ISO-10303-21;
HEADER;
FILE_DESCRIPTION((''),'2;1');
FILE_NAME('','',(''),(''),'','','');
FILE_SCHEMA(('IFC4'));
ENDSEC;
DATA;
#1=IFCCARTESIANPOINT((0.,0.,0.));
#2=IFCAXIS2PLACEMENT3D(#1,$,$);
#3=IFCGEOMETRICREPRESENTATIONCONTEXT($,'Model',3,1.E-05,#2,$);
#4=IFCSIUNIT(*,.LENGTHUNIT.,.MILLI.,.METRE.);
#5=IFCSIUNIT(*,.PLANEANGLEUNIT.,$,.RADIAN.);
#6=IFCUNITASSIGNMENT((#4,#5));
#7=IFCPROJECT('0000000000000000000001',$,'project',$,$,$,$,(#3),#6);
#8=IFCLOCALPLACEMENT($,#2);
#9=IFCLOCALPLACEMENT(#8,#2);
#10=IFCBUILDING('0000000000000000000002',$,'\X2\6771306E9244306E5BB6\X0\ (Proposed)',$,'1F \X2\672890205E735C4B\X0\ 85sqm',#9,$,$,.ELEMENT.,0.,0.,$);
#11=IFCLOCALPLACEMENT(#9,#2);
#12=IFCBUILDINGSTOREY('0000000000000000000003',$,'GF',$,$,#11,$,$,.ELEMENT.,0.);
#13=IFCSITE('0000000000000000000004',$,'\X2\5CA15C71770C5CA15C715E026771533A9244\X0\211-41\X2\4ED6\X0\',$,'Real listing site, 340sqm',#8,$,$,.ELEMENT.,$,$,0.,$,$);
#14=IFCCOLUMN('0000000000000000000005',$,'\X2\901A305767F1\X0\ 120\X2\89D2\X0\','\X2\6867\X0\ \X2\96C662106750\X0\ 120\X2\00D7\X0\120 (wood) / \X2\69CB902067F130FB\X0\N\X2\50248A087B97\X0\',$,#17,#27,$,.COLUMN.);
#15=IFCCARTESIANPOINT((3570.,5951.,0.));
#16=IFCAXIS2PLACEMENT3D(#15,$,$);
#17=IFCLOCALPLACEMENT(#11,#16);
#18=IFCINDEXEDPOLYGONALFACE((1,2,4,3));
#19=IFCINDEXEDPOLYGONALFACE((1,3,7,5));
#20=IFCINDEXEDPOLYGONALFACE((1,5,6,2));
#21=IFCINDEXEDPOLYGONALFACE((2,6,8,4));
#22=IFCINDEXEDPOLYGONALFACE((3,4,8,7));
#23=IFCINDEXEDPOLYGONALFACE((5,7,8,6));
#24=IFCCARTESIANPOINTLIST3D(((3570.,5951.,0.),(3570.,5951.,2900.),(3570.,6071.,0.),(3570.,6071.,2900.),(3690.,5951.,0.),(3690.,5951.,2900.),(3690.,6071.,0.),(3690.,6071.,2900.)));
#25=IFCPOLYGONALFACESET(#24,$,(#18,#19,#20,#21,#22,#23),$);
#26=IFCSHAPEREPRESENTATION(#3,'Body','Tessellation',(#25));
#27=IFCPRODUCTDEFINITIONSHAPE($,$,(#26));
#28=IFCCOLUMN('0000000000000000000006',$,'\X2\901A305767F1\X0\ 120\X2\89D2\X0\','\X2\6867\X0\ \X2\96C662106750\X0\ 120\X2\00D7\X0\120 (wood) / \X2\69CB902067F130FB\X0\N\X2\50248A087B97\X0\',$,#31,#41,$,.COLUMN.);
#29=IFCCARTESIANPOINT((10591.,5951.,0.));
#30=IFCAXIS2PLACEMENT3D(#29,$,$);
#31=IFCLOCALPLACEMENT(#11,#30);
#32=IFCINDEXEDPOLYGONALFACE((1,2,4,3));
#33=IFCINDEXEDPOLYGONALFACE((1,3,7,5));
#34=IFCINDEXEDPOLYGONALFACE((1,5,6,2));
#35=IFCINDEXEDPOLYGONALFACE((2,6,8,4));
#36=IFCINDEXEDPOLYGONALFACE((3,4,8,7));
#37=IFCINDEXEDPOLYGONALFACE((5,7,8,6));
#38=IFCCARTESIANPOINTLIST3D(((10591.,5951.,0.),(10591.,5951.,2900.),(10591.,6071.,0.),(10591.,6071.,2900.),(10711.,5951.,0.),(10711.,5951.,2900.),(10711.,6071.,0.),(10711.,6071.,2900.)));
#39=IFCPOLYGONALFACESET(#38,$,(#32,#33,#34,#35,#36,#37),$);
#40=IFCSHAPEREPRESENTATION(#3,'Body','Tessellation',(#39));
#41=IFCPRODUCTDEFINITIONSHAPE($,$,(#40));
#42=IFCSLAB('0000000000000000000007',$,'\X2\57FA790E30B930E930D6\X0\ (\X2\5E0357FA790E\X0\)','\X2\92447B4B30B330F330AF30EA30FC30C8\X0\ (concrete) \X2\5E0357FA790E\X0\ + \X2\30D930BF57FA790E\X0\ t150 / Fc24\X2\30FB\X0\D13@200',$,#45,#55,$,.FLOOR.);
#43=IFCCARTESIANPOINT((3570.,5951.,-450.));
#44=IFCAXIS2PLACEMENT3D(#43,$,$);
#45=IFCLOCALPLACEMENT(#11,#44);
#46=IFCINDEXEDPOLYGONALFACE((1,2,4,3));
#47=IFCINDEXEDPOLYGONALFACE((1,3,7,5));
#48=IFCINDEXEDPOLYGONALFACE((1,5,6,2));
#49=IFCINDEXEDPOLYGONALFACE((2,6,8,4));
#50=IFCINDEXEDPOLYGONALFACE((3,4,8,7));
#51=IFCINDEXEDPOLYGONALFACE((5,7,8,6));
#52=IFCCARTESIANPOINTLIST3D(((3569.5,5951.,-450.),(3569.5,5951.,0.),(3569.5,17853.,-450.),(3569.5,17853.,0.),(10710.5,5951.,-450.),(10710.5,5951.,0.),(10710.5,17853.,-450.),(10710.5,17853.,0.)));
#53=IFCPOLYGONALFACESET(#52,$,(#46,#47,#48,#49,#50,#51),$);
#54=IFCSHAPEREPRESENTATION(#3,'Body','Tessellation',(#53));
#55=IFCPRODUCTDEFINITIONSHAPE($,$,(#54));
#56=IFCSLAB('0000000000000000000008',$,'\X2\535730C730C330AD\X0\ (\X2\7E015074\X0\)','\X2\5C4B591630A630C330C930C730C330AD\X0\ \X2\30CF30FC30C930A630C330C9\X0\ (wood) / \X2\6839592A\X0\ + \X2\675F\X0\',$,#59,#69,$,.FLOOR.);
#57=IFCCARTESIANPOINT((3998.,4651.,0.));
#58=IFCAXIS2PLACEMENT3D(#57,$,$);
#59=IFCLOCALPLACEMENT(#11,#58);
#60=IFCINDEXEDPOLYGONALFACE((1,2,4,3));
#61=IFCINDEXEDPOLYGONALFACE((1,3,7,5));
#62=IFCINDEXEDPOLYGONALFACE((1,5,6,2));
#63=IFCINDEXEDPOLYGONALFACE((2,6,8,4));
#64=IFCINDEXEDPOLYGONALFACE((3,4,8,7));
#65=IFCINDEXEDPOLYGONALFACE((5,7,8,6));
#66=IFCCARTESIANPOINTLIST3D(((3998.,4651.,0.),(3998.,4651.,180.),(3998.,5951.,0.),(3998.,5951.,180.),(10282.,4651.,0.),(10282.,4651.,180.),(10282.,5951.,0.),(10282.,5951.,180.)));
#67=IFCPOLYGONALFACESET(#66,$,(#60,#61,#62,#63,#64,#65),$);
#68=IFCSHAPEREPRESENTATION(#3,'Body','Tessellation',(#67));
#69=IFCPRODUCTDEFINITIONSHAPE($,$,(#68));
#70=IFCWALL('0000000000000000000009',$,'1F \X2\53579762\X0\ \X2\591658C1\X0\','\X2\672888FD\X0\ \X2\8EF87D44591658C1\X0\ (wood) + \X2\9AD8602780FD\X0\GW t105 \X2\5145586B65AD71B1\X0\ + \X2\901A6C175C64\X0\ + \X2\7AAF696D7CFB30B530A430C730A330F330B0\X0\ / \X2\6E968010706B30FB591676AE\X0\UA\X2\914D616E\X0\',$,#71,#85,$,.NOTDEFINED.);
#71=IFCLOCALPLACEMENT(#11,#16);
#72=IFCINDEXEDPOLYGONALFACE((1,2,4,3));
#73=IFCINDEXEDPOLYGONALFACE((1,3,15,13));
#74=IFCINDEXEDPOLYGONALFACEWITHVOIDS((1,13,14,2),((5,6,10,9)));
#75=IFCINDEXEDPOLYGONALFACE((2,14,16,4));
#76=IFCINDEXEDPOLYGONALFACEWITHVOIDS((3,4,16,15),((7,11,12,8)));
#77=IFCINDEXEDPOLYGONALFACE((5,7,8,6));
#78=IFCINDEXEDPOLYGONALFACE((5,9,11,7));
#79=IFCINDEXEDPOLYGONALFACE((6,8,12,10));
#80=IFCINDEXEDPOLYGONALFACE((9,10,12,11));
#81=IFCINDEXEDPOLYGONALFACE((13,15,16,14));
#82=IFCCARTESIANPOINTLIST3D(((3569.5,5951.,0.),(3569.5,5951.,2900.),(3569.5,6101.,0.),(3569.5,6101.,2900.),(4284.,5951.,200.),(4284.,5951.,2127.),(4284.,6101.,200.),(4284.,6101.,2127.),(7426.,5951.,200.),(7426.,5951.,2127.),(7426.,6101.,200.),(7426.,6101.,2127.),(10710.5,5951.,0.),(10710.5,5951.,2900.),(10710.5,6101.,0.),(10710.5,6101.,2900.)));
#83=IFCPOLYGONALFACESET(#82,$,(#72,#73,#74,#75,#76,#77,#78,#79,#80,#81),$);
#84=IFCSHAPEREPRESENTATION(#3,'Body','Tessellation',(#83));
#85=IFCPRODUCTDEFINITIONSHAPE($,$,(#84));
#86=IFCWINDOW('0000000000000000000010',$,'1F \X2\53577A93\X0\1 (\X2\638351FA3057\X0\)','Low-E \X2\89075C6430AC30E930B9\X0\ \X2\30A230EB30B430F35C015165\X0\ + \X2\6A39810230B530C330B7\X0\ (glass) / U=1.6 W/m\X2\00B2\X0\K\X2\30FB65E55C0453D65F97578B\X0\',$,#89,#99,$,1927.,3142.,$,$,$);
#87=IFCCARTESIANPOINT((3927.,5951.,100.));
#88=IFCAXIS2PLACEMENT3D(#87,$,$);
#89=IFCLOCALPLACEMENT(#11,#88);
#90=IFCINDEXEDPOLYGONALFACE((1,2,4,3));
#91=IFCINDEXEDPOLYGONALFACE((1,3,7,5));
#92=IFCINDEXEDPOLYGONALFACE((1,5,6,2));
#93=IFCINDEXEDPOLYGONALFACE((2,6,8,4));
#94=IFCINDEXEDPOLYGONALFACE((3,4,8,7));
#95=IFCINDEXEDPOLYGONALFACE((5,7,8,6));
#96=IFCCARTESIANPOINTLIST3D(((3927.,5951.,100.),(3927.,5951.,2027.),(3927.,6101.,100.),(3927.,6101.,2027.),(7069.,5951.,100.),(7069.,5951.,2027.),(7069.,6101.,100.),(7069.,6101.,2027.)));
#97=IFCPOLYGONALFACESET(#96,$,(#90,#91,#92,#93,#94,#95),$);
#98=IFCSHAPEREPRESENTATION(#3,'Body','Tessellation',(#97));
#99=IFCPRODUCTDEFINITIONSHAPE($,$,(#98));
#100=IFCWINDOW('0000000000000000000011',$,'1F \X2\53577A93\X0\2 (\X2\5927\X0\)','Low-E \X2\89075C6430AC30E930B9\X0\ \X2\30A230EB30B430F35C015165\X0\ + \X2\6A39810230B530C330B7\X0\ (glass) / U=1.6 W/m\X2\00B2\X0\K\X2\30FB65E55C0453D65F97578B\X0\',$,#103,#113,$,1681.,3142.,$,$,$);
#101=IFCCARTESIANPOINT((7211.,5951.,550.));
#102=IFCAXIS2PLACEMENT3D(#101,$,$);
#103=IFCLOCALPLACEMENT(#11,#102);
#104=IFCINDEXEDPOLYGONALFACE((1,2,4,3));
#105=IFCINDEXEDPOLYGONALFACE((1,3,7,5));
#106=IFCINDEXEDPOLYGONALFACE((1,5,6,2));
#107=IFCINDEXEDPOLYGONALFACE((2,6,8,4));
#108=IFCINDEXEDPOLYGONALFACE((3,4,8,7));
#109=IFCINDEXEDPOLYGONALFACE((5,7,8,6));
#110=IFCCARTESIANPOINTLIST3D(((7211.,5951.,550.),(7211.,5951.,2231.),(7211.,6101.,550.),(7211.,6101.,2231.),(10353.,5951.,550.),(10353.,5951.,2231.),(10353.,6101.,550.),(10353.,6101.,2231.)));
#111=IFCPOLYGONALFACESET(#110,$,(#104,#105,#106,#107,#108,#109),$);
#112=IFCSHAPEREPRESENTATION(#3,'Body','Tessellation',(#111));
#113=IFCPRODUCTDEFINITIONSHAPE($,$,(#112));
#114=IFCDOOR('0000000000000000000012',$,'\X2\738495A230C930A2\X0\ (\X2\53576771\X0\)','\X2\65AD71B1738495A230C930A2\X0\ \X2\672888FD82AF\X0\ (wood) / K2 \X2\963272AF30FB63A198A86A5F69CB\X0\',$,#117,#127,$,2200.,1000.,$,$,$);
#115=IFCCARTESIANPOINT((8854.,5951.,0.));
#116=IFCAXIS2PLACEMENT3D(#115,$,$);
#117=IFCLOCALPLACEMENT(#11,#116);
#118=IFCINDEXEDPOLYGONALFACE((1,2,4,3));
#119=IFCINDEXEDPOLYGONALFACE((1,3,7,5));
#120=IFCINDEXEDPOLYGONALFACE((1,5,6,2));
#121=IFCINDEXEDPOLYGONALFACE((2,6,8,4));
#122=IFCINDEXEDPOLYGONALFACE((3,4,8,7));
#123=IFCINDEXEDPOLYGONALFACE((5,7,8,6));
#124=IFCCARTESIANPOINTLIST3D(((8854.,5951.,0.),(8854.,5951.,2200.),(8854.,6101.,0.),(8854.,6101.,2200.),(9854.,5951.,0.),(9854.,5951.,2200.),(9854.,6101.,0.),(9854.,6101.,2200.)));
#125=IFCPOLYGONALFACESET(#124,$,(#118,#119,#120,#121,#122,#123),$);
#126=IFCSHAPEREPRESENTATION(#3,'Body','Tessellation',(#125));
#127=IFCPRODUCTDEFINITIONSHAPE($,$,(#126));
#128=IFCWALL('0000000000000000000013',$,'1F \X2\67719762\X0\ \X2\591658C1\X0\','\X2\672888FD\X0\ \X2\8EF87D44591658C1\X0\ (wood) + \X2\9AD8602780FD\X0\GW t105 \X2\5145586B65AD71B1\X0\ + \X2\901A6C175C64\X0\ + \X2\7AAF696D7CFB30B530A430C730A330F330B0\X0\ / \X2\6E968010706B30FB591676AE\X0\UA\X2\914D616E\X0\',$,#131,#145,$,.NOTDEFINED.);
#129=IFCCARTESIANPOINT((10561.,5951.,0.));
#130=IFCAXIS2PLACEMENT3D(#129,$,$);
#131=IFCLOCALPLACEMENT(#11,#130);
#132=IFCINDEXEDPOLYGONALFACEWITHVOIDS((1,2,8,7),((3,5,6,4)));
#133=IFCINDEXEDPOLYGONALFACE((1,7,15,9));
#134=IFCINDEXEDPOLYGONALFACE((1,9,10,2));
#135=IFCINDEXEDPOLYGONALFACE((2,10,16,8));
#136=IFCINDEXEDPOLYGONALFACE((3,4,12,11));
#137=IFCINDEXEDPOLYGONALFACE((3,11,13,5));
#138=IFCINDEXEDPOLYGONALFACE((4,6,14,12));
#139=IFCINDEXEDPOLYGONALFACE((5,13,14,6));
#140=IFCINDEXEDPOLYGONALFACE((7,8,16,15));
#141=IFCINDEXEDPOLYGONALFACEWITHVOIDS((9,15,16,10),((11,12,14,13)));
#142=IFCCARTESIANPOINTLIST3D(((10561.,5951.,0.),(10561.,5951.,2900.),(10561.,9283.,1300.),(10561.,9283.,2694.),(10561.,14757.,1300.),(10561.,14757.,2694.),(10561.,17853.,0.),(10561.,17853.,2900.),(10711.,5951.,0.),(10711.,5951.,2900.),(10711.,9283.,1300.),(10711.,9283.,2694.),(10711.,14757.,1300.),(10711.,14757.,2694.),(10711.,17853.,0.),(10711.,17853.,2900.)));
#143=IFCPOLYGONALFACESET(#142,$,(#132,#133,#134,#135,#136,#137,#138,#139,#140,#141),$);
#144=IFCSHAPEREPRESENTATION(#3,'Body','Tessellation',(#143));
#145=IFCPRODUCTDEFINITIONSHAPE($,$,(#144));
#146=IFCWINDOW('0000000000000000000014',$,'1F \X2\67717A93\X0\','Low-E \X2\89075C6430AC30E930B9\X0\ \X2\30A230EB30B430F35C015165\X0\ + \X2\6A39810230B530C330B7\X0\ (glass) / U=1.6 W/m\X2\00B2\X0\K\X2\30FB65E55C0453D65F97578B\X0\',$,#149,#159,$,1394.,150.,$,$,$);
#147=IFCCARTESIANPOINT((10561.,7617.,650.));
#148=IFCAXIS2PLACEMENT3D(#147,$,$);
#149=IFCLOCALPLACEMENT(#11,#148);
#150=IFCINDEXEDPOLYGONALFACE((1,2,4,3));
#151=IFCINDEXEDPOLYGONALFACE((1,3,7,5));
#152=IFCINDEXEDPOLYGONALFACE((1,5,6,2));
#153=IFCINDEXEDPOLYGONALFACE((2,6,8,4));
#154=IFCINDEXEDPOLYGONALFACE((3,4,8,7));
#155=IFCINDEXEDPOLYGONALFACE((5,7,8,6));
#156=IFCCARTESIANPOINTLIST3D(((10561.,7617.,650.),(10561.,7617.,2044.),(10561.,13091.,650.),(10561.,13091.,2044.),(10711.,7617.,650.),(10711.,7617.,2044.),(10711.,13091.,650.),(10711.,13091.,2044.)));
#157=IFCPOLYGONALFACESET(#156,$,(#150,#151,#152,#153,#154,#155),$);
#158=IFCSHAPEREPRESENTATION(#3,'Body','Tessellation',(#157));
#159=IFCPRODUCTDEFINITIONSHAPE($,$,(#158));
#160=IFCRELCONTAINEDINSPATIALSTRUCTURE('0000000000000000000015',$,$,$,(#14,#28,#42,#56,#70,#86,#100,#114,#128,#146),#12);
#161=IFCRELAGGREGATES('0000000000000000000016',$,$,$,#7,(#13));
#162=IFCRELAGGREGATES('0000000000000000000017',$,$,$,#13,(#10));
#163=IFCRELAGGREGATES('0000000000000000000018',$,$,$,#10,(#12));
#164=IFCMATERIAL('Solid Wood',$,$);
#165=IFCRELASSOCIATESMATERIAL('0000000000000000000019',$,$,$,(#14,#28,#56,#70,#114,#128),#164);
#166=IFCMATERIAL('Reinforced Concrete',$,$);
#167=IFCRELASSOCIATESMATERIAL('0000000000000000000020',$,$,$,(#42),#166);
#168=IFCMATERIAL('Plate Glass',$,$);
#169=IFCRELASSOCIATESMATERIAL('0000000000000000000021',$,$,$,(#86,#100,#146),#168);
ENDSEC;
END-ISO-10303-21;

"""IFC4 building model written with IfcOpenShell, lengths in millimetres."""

from ifc_helpers import new_model, si_unit, frame, frame_2d, origin, place, context, project, spatial, rectangle, extrude, material, element, fill, save


model = new_model("IFC4")

# Units and contexts
model_context = context("Model", 3, precision=1e-05, world=origin())
ifc_project = project(units=[si_unit("LENGTHUNIT", "METRE", prefix="MILLI"), si_unit("PLANEANGLEUNIT", "RADIAN")], contexts=[model_context])

# Site, building, storey
site_placement = place(None, origin())
site = spatial("IfcSite", under=ifc_project, at=site_placement, Name="岡山県岡山市東区鉄211-41他", ObjectType="Real listing site, 340sqm", CompositionType="ELEMENT", RefElevation=0.0)
building_placement = place(site_placement, origin())
building = spatial("IfcBuilding", under=site, at=building_placement, Name="東の鉄の家 (Proposed)", ObjectType="1F 木造平屋 85sqm", CompositionType="ELEMENT", ElevationOfRefHeight=0.0, ElevationOfTerrain=0.0)
storey_placement = place(building_placement, origin())
storey = spatial("IfcBuildingStorey", under=building, at=storey_placement, Name="GF", CompositionType="ELEMENT", Elevation=0.0)

# Columns
ifc_material_1 = material(Name="Solid Wood")
column_1_placement = place(storey_placement, frame((3570.0, 5951.0, 0.0)))
element("IfcColumn", 1, at=column_1_placement, inside=storey, material=ifc_material_1, Name="通し柱 120角", Description="桧 集成材 120×120 (wood) / 構造柱・N値計算", PredefinedType="COLUMN", context=model_context, shape_type="SweptSolid", body=[
    extrude(rectangle(XDim=120.0, YDim=120.0, at=frame_2d((60.0, 60.0))), frame((3570.0, 5951.0, 0.0)), (0.0, 0.0, 1.0), 2900.0),
])
column_2_placement = place(storey_placement, frame((10591.0, 5951.0, 0.0)))
element("IfcColumn", 2, at=column_2_placement, inside=storey, material=ifc_material_1, Name="通し柱 120角", Description="桧 集成材 120×120 (wood) / 構造柱・N値計算", PredefinedType="COLUMN", context=model_context, shape_type="SweptSolid", body=[
    extrude(rectangle(XDim=120.0, YDim=120.0, at=frame_2d((60.0, 60.0))), frame((10591.0, 5951.0, 0.0)), (0.0, 0.0, 1.0), 2900.0),
])

# Slabs
ifc_material_2 = material(Name="Reinforced Concrete")
slab_1_placement = place(storey_placement, frame((3570.0, 5951.0, -450.0)))
element("IfcSlab", 3, at=slab_1_placement, inside=storey, material=ifc_material_2, Name="基礎スラブ (布基礎)", Description="鉄筋コンクリート (concrete) 布基礎 + ベタ基礎 t150 / Fc24・D13@200", PredefinedType="FLOOR", context=model_context, shape_type="SweptSolid", body=[
    extrude(rectangle(XDim=7141.0, YDim=11902.0, at=frame_2d((3570.0, 5951.0))), frame((3570.0, 5951.0, -450.0)), (0.0, 0.0, 1.0), 450.0),
])
slab_2_placement = place(storey_placement, frame((3998.0, 4651.0, 0.0)))
element("IfcSlab", 4, at=slab_2_placement, inside=storey, material=ifc_material_1, Name="南デッキ (縁側)", Description="屋外ウッドデッキ ハードウッド (wood) / 根太 + 束", PredefinedType="FLOOR", context=model_context, shape_type="SweptSolid", body=[
    extrude(rectangle(XDim=6284.0, YDim=1300.0, at=frame_2d((3142.0, 650.0))), frame((3998.0, 4651.0, 0.0)), (0.0, 0.0, 1.0), 180.0),
])

# Wall, openings, windows, door
wall_1_placement = place(storey_placement, frame((3570.0, 5951.0, 0.0)))
wall_1 = element("IfcWall", 5, at=wall_1_placement, inside=storey, material=ifc_material_1, Name="1F 南面 外壁", Description="木製 軸組外壁 (wood) + 高性能GW t105 充填断熱 + 通気層 + 窯業系サイディング / 準耐火・外皮UA配慮", PredefinedType="NOTDEFINED", context=model_context, shape_type="SweptSolid", body=[
    extrude(rectangle(XDim=7141.0, YDim=150.0, at=frame_2d((3570.0, 75.0))), frame((3570.0, 5951.0, 0.0)), (0.0, 0.0, 1.0), 2900.0),
])
opening_1_placement = place(storey_placement, frame((3927.0, 5951.0, 100.0)))
opening_1 = element("IfcOpeningElement", 6, at=opening_1_placement, cuts=wall_1, PredefinedType="NOTDEFINED", context=model_context, shape_type="SweptSolid", body=[
    extrude(rectangle(XDim=3142.0, YDim=150.0, at=frame_2d((1571.0, 75.0))), frame((3927.0, 5951.0, 100.0)), (0.0, 0.0, 1.0), 1927.0),
])
opening_2_placement = place(storey_placement, frame((7211.0, 5951.0, 550.0)))
opening_2 = element("IfcOpeningElement", 7, at=opening_2_placement, cuts=wall_1, PredefinedType="NOTDEFINED", context=model_context, shape_type="SweptSolid", body=[
    extrude(rectangle(XDim=3142.0, YDim=150.0, at=frame_2d((1571.0, 75.0))), frame((7211.0, 5951.0, 550.0)), (0.0, 0.0, 1.0), 1681.0),
])
opening_3_placement = place(storey_placement, frame((8854.0, 5951.0, 0.0)))
opening_3 = element("IfcOpeningElement", 8, at=opening_3_placement, cuts=wall_1, PredefinedType="NOTDEFINED", context=model_context, shape_type="SweptSolid", body=[
    extrude(rectangle(XDim=1000.0, YDim=150.0, at=frame_2d((500.0, 75.0))), frame((8854.0, 5951.0, 0.0)), (0.0, 0.0, 1.0), 2200.0),
])
ifc_material_3 = material(Name="Plate Glass")
window_1_placement = place(storey_placement, frame((3927.0, 5951.0, 100.0)))
window_1 = element("IfcWindow", 9, at=window_1_placement, inside=storey, material=ifc_material_3, Name="1F 南窓1 (掃出し)", Description="Low-E 複層ガラス アルゴン封入 + 樹脂サッシ (glass) / U=1.6 W/m²K・日射取得型", OverallHeight=1927.0, OverallWidth=3142.0, context=model_context, shape_type="SweptSolid", body=[
    extrude(rectangle(XDim=3142.0, YDim=150.0, at=frame_2d((1571.0, 75.0))), frame((3927.0, 5951.0, 100.0)), (0.0, 0.0, 1.0), 1927.0),
])
fill(opening_1, window_1)
window_2_placement = place(storey_placement, frame((7211.0, 5951.0, 550.0)))
window_2 = element("IfcWindow", 10, at=window_2_placement, inside=storey, material=ifc_material_3, Name="1F 南窓2 (大)", Description="Low-E 複層ガラス アルゴン封入 + 樹脂サッシ (glass) / U=1.6 W/m²K・日射取得型", OverallHeight=1681.0, OverallWidth=3142.0, context=model_context, shape_type="SweptSolid", body=[
    extrude(rectangle(XDim=3142.0, YDim=150.0, at=frame_2d((1571.0, 75.0))), frame((7211.0, 5951.0, 550.0)), (0.0, 0.0, 1.0), 1681.0),
])
fill(opening_2, window_2)
door_placement = place(storey_placement, frame((8854.0, 5951.0, 0.0)))
door = element("IfcDoor", 11, at=door_placement, inside=storey, material=ifc_material_1, Name="玄関ドア (南東)", Description="断熱玄関ドア 木製芯 (wood) / K2 防犯・採風機構", OverallHeight=2200.0, OverallWidth=1000.0, context=model_context, shape_type="SweptSolid", body=[
    extrude(rectangle(XDim=1000.0, YDim=150.0, at=frame_2d((500.0, 75.0))), frame((8854.0, 5951.0, 0.0)), (0.0, 0.0, 1.0), 2200.0),
])
fill(opening_3, door)

# Wall, opening, window
wall_2_placement = place(storey_placement, frame((10561.0, 5951.0, 0.0)))
wall_2 = element("IfcWall", 12, at=wall_2_placement, inside=storey, material=ifc_material_1, Name="1F 東面 外壁", Description="木製 軸組外壁 (wood) + 高性能GW t105 充填断熱 + 通気層 + 窯業系サイディング / 準耐火・外皮UA配慮", PredefinedType="NOTDEFINED", context=model_context, shape_type="SweptSolid", body=[
    extrude(rectangle(XDim=150.0, YDim=11902.0, at=frame_2d((75.0, 5951.0))), frame((10561.0, 5951.0, 0.0)), (0.0, 0.0, 1.0), 2900.0),
])
opening_4_placement = place(storey_placement, frame((10561.0, 7617.0, 650.0)))
opening_4 = element("IfcOpeningElement", 13, at=opening_4_placement, cuts=wall_2, PredefinedType="NOTDEFINED", context=model_context, shape_type="SweptSolid", body=[
    extrude(rectangle(XDim=150.0, YDim=5474.0, at=frame_2d((75.0, 2737.0))), frame((10561.0, 7617.0, 650.0)), (0.0, 0.0, 1.0), 1394.0),
])
window_3_placement = place(storey_placement, frame((10561.0, 7617.0, 650.0)))
window_3 = element("IfcWindow", 14, at=window_3_placement, inside=storey, material=ifc_material_3, Name="1F 東窓", Description="Low-E 複層ガラス アルゴン封入 + 樹脂サッシ (glass) / U=1.6 W/m²K・日射取得型", OverallHeight=1394.0, OverallWidth=150.0, context=model_context, shape_type="SweptSolid", body=[
    extrude(rectangle(XDim=150.0, YDim=5474.0, at=frame_2d((75.0, 2737.0))), frame((10561.0, 7617.0, 650.0)), (0.0, 0.0, 1.0), 1394.0),
])
fill(opening_4, window_3)

save(model, "model.ifc")
